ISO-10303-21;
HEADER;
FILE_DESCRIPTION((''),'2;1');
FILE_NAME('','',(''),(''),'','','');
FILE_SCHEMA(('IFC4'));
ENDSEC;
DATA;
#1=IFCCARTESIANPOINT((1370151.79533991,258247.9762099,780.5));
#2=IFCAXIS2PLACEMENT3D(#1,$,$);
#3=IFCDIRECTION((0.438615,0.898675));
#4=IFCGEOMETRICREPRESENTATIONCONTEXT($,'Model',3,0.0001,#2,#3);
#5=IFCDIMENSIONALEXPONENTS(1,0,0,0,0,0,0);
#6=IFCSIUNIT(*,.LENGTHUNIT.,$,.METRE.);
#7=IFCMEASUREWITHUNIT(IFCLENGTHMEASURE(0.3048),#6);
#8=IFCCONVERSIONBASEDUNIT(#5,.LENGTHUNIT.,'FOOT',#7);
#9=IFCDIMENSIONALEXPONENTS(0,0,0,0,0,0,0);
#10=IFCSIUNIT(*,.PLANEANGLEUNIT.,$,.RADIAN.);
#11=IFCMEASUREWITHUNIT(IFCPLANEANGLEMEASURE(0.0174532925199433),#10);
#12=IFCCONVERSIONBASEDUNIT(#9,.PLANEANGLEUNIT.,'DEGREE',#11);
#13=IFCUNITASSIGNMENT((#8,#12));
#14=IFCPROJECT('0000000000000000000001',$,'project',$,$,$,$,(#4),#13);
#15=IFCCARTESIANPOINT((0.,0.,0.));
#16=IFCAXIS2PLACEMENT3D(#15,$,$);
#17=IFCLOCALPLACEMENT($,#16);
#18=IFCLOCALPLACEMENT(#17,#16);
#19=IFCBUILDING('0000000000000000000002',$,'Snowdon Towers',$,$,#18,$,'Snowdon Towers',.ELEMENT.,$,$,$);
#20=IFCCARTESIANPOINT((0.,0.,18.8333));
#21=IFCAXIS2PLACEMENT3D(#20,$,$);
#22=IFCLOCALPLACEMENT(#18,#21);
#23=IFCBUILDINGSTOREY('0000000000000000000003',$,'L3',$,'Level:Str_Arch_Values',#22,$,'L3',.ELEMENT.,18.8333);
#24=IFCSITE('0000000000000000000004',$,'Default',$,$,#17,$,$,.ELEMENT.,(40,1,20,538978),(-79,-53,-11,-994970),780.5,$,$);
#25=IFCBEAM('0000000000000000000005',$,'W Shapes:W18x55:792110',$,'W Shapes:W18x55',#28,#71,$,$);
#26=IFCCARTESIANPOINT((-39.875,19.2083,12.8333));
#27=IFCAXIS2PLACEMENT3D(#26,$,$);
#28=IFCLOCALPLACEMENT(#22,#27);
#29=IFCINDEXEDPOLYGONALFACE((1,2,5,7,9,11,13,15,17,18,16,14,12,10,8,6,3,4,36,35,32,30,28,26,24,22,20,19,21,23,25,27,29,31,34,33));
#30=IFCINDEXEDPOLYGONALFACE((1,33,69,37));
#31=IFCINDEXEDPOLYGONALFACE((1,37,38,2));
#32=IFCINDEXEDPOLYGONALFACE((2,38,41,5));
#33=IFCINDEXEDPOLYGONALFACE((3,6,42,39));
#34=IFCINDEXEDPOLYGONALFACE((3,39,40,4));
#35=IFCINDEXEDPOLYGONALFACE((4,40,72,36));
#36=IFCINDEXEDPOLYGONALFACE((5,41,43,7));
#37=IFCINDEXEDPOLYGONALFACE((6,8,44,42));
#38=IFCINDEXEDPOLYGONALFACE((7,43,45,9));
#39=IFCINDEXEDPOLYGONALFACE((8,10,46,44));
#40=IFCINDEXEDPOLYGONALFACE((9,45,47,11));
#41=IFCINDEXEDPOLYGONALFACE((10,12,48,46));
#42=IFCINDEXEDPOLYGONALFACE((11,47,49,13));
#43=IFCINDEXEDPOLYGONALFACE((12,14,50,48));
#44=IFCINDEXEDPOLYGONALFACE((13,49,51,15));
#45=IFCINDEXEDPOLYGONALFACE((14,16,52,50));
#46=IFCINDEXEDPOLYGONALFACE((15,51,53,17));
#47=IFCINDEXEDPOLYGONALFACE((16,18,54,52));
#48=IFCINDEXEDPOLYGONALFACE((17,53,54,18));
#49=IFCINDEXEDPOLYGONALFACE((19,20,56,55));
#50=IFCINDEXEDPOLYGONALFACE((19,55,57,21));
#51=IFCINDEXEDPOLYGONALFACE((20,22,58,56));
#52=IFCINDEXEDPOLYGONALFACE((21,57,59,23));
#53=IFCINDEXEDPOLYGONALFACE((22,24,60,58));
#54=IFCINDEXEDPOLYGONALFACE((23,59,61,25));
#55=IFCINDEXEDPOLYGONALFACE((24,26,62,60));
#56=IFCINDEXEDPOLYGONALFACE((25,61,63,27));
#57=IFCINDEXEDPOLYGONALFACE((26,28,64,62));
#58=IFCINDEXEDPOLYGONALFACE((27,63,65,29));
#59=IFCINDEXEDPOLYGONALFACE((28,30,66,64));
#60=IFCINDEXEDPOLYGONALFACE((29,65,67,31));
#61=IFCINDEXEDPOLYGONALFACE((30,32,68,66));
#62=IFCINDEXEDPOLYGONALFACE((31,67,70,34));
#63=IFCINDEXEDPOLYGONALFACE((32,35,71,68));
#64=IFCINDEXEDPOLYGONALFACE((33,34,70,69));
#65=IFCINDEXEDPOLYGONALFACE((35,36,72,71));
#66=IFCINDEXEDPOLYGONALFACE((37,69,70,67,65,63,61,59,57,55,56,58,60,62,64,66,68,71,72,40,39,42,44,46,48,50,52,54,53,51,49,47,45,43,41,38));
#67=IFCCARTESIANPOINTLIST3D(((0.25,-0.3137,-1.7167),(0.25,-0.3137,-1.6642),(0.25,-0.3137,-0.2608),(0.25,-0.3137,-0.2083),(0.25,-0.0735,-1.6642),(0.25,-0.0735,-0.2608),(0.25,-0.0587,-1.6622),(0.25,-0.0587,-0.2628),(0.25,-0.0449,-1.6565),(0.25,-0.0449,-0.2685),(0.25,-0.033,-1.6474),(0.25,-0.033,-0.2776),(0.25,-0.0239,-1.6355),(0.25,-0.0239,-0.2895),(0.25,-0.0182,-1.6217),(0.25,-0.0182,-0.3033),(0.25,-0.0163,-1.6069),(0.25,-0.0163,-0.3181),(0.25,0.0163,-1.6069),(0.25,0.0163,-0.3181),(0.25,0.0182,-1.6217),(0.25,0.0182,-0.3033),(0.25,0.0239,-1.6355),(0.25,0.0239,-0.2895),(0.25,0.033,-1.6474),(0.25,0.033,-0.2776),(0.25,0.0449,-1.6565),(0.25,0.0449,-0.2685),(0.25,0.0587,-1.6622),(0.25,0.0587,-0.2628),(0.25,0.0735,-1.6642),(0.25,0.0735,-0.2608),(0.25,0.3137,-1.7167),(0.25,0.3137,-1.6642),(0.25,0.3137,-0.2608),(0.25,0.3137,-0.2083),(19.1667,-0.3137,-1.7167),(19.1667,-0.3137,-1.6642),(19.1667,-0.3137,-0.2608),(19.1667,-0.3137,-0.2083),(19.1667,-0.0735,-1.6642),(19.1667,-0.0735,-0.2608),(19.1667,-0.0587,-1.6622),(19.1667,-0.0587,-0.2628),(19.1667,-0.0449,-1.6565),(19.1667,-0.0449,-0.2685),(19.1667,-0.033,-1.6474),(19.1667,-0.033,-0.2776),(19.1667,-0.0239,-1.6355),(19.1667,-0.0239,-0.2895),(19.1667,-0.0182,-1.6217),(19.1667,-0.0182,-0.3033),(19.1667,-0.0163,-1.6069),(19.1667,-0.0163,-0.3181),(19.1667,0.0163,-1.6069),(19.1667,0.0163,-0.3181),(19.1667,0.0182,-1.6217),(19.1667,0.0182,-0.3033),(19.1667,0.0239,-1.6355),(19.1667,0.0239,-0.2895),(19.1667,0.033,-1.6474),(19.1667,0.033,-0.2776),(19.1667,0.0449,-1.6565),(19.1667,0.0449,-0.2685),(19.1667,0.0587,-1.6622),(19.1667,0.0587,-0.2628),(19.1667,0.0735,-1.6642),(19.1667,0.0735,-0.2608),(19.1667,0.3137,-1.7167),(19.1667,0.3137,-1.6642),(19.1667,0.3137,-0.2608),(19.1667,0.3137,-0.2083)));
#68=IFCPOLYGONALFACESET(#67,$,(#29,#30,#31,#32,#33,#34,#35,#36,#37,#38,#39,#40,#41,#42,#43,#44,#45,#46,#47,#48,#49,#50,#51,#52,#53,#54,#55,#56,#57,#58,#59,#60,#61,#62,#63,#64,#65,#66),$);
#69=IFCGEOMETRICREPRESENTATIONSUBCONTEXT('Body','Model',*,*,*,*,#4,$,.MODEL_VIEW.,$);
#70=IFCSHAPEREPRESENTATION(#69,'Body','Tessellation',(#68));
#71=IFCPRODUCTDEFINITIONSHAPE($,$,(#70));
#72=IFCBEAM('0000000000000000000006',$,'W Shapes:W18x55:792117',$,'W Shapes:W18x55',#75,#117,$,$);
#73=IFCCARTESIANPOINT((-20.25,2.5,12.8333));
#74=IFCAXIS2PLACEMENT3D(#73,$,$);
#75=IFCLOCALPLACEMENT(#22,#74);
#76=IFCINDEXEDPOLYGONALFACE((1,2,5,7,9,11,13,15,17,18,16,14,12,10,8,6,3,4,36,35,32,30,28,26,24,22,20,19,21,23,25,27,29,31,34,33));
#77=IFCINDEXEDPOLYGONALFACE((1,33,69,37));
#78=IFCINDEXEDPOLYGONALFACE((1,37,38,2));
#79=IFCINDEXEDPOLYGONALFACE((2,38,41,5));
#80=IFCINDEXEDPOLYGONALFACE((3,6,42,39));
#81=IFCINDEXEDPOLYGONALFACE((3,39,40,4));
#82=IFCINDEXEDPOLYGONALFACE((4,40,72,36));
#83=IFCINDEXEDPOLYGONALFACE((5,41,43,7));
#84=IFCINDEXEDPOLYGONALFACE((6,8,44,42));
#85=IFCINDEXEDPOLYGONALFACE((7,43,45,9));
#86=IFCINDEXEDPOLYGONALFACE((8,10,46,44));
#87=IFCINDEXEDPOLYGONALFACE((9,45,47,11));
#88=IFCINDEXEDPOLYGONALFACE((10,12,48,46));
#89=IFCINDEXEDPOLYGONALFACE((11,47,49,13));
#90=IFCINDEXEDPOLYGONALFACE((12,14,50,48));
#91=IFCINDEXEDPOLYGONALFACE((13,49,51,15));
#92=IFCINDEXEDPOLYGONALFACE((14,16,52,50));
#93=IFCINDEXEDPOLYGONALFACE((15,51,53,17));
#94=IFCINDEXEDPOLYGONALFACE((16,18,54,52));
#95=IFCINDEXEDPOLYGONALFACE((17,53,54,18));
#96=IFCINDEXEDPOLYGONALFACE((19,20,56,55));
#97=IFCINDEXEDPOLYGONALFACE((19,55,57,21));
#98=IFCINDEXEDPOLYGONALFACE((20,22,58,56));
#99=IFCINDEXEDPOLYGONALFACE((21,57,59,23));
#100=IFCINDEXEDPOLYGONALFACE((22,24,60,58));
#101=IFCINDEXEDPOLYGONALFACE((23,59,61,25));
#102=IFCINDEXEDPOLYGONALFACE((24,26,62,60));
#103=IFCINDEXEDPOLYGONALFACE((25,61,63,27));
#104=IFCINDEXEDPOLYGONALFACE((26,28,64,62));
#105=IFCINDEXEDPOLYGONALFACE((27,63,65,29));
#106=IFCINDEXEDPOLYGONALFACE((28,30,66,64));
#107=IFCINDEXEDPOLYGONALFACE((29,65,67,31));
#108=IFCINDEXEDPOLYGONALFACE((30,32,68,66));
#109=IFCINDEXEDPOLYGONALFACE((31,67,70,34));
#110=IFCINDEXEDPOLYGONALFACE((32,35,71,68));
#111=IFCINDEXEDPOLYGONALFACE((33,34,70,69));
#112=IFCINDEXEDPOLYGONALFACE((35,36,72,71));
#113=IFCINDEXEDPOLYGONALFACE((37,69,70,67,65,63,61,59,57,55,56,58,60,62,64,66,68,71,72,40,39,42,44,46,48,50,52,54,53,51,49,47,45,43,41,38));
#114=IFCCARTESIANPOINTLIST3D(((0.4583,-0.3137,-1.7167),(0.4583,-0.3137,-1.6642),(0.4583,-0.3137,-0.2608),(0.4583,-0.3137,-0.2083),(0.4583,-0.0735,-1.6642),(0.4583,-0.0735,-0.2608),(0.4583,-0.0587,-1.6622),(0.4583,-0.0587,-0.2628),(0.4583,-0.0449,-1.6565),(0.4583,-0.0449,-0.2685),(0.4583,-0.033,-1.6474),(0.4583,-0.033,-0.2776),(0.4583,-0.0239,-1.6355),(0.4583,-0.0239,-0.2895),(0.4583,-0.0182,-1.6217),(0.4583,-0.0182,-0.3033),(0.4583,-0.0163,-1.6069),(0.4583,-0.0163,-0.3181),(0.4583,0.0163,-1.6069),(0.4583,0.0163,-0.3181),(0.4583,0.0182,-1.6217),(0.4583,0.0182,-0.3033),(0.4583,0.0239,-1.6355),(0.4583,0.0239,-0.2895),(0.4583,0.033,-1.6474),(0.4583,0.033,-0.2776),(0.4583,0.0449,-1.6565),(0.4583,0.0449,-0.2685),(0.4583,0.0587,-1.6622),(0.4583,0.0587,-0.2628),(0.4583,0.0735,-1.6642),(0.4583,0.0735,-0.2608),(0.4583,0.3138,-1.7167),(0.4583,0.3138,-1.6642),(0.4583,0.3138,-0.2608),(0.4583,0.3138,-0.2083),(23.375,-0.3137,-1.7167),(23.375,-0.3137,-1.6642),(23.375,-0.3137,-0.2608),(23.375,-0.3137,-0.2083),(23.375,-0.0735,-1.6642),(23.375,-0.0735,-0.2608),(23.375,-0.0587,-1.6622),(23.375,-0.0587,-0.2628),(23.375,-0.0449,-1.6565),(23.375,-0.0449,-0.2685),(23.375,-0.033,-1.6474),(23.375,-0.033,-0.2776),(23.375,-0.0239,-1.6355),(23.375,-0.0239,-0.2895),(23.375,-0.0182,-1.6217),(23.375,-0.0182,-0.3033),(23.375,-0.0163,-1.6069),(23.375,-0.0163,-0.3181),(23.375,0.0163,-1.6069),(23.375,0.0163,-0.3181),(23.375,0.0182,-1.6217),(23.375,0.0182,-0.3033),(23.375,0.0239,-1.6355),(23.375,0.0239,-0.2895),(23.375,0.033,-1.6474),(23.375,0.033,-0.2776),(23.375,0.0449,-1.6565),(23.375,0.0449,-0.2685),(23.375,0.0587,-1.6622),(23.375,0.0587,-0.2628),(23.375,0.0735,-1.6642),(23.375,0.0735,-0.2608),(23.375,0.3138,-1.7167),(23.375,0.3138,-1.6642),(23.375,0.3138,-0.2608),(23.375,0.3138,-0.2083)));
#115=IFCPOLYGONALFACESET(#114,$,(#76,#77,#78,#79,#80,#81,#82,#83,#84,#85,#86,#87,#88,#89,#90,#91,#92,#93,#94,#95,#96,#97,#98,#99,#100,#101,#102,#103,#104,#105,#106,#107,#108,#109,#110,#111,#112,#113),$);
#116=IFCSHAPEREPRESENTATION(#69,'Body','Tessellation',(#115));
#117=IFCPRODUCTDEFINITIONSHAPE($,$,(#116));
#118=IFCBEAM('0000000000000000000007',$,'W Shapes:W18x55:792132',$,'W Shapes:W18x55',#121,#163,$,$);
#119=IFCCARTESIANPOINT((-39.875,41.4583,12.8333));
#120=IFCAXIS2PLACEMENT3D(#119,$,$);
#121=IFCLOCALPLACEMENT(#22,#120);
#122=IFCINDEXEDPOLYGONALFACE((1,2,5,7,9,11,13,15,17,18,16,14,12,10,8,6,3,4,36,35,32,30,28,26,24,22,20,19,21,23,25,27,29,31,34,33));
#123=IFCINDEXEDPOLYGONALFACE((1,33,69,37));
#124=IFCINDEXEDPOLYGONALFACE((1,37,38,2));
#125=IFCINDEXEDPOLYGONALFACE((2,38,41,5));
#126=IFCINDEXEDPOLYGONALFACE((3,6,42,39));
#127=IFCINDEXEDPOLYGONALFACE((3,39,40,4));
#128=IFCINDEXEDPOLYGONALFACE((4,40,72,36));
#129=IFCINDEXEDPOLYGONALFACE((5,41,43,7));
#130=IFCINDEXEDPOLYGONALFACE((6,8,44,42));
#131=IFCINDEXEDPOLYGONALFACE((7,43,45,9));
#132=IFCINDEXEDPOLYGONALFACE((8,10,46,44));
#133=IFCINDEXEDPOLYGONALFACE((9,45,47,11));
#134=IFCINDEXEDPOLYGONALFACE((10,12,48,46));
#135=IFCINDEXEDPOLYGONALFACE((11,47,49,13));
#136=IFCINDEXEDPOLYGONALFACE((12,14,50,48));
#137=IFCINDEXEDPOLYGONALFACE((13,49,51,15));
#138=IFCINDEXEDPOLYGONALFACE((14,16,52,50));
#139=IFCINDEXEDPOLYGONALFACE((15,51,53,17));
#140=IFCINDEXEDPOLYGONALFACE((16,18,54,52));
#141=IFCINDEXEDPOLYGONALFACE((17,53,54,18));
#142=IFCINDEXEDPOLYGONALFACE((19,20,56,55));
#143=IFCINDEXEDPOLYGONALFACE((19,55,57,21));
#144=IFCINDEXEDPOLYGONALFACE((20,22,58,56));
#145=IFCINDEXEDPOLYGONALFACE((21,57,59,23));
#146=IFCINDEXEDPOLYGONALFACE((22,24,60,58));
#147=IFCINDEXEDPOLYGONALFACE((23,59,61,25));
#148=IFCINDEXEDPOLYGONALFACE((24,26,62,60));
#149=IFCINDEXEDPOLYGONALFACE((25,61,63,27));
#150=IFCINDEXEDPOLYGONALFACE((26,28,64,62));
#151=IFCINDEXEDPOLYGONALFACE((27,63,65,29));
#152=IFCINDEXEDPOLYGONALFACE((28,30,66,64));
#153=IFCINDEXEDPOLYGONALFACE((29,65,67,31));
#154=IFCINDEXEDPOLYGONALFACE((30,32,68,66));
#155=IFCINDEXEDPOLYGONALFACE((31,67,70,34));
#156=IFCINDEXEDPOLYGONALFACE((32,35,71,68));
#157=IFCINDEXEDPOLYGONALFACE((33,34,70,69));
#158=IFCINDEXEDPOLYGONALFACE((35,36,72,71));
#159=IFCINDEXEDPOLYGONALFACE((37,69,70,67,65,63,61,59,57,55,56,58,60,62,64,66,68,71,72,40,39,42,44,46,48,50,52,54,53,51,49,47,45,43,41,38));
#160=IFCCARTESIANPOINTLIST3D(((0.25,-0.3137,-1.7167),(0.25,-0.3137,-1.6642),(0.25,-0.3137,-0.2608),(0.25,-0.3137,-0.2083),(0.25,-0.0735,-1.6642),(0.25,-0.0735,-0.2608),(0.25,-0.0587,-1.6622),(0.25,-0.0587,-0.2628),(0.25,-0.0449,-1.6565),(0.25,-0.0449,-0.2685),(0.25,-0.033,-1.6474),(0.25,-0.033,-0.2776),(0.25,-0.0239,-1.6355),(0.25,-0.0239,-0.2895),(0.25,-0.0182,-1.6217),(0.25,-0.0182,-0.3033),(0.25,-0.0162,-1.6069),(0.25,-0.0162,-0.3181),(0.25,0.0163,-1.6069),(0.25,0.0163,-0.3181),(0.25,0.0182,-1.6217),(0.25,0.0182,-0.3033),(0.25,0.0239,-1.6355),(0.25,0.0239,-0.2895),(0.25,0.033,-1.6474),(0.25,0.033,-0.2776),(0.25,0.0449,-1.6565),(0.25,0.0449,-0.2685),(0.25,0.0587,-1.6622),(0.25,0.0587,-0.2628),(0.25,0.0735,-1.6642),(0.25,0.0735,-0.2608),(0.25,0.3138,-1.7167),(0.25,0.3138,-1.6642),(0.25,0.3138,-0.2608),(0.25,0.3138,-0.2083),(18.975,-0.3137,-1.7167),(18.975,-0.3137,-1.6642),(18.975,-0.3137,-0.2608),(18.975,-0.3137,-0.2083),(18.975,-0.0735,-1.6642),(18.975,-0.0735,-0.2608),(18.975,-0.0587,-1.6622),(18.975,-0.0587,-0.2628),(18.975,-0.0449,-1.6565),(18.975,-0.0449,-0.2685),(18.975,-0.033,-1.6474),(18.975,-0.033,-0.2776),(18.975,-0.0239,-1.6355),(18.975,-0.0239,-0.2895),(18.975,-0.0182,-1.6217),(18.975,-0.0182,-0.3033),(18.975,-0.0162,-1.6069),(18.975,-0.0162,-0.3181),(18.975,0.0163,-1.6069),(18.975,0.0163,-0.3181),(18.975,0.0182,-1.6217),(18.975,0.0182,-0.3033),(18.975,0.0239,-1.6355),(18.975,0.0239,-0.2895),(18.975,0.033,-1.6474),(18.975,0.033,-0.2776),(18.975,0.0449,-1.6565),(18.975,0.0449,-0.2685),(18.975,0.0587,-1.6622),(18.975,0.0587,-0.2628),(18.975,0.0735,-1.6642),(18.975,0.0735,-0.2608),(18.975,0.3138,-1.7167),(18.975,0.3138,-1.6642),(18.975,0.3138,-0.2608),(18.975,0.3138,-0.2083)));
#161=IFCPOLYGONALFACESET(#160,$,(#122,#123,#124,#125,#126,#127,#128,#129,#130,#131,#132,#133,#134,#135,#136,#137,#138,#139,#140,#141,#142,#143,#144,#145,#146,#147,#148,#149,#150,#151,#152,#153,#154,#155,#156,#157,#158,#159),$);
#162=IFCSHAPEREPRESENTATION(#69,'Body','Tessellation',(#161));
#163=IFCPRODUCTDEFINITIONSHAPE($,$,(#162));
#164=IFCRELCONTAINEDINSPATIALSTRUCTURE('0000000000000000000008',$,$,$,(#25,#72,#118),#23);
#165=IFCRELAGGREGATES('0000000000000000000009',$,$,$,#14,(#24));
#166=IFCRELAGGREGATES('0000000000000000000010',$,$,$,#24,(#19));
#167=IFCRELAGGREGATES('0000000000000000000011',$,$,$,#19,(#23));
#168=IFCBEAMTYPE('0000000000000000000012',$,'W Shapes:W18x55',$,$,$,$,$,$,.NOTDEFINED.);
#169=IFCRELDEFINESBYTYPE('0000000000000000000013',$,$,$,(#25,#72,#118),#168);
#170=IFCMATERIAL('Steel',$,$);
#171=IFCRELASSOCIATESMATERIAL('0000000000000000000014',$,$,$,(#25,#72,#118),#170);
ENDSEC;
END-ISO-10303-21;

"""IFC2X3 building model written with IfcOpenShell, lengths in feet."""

from ifc_helpers import new_model, entity, si_unit, converted_unit, direction, frame, frame_2d, origin, place, context, subcontext, project, spatial, i_section, extrude, material, type_object, element, save


model = new_model("IFC2X3")

# Units and contexts
model_context = context("Model", 3, precision=0.0001, world=frame((1370151.79533991, 258247.9762099, 780.5)), true_north=direction((0.438615, 0.898675)))
body_context = subcontext(model_context, "Body", "Model", "MODEL_VIEW")
ifc_project = project(units=[converted_unit("LENGTHUNIT", "FOOT", entity("IfcLengthMeasure", 0.3048), si_unit("LENGTHUNIT", "METRE"), dimensions=[1, 0, 0, 0, 0, 0, 0]), converted_unit("PLANEANGLEUNIT", "DEGREE", entity("IfcPlaneAngleMeasure", 0.0174532925199433), si_unit("PLANEANGLEUNIT", "RADIAN"), dimensions=[0, 0, 0, 0, 0, 0, 0])], contexts=[model_context])

# Site, building, storey
site_placement = place(None, origin())
site = spatial("IfcSite", under=ifc_project, at=site_placement, Name="Default", CompositionType="ELEMENT", RefLatitude=(40, 1, 20, 538978), RefLongitude=(-79, -53, -11, -994970), RefElevation=780.5)
building_placement = place(site_placement, origin())
building = spatial("IfcBuilding", under=site, at=building_placement, Name="Snowdon Towers", LongName="Snowdon Towers", CompositionType="ELEMENT")
storey_placement = place(building_placement, frame((0.0, 0.0, 18.8333)))
storey = spatial("IfcBuildingStorey", under=building, at=storey_placement, Name="L3", ObjectType="Level:Str_Arch_Values", LongName="L3", CompositionType="ELEMENT", Elevation=18.8333)

# Beams
ifc_material_1 = material(Name="Steel")
beam_type = type_object("IfcBeamType", Name="W Shapes:W18x55", PredefinedType="NOTDEFINED")
beam_1_placement = place(storey_placement, frame((-39.875, 19.2083, 12.8333)))
element("IfcBeam", 1, at=beam_1_placement, inside=storey, type_object=beam_type, material=ifc_material_1, Name="W Shapes:W18x55:792110", ObjectType="W Shapes:W18x55", context=body_context, shape_type="SweptSolid", body=[
    extrude(i_section(OverallWidth=0.6275, OverallDepth=1.5083, WebThickness=0.0325, FlangeThickness=0.0525, FilletRadius=0.0573, at=frame_2d((0.0, 0.0), x_axis=(0.0, 1.0))), frame((0.25, 0.0, -0.9625), z_axis=(1.0, 0.0, 0.0), x_axis=(0.0, 0.0, -1.0)), (0.0, 0.0, 1.0), 18.9167),
])
beam_2_placement = place(storey_placement, frame((-20.25, 2.5, 12.8333)))
element("IfcBeam", 2, at=beam_2_placement, inside=storey, type_object=beam_type, material=ifc_material_1, Name="W Shapes:W18x55:792117", ObjectType="W Shapes:W18x55", context=body_context, shape_type="SweptSolid", body=[
    extrude(i_section(OverallWidth=0.6275, OverallDepth=1.5083, WebThickness=0.0325, FlangeThickness=0.0525, FilletRadius=0.0573, at=frame_2d((0.0, 0.0), x_axis=(0.0, 1.0))), frame((0.4583, 0.0, -0.9625), z_axis=(1.0, 0.0, 0.0), x_axis=(0.0, 0.0, -1.0)), (0.0, 0.0, 1.0), 22.9167),
])
beam_3_placement = place(storey_placement, frame((-39.875, 41.4583, 12.8333)))
element("IfcBeam", 3, at=beam_3_placement, inside=storey, type_object=beam_type, material=ifc_material_1, Name="W Shapes:W18x55:792132", ObjectType="W Shapes:W18x55", context=body_context, shape_type="SweptSolid", body=[
    extrude(i_section(OverallWidth=0.6275, OverallDepth=1.5083, WebThickness=0.0325, FlangeThickness=0.0525, FilletRadius=0.0573, at=frame_2d((0.0, 0.0), x_axis=(0.0, 1.0))), frame((0.25, 0.0, -0.9625), z_axis=(1.0, 0.0, 0.0), x_axis=(0.0, 0.0, -1.0)), (0.0, 0.0, 1.0), 18.725),
])

save(model, "model.ifc")
